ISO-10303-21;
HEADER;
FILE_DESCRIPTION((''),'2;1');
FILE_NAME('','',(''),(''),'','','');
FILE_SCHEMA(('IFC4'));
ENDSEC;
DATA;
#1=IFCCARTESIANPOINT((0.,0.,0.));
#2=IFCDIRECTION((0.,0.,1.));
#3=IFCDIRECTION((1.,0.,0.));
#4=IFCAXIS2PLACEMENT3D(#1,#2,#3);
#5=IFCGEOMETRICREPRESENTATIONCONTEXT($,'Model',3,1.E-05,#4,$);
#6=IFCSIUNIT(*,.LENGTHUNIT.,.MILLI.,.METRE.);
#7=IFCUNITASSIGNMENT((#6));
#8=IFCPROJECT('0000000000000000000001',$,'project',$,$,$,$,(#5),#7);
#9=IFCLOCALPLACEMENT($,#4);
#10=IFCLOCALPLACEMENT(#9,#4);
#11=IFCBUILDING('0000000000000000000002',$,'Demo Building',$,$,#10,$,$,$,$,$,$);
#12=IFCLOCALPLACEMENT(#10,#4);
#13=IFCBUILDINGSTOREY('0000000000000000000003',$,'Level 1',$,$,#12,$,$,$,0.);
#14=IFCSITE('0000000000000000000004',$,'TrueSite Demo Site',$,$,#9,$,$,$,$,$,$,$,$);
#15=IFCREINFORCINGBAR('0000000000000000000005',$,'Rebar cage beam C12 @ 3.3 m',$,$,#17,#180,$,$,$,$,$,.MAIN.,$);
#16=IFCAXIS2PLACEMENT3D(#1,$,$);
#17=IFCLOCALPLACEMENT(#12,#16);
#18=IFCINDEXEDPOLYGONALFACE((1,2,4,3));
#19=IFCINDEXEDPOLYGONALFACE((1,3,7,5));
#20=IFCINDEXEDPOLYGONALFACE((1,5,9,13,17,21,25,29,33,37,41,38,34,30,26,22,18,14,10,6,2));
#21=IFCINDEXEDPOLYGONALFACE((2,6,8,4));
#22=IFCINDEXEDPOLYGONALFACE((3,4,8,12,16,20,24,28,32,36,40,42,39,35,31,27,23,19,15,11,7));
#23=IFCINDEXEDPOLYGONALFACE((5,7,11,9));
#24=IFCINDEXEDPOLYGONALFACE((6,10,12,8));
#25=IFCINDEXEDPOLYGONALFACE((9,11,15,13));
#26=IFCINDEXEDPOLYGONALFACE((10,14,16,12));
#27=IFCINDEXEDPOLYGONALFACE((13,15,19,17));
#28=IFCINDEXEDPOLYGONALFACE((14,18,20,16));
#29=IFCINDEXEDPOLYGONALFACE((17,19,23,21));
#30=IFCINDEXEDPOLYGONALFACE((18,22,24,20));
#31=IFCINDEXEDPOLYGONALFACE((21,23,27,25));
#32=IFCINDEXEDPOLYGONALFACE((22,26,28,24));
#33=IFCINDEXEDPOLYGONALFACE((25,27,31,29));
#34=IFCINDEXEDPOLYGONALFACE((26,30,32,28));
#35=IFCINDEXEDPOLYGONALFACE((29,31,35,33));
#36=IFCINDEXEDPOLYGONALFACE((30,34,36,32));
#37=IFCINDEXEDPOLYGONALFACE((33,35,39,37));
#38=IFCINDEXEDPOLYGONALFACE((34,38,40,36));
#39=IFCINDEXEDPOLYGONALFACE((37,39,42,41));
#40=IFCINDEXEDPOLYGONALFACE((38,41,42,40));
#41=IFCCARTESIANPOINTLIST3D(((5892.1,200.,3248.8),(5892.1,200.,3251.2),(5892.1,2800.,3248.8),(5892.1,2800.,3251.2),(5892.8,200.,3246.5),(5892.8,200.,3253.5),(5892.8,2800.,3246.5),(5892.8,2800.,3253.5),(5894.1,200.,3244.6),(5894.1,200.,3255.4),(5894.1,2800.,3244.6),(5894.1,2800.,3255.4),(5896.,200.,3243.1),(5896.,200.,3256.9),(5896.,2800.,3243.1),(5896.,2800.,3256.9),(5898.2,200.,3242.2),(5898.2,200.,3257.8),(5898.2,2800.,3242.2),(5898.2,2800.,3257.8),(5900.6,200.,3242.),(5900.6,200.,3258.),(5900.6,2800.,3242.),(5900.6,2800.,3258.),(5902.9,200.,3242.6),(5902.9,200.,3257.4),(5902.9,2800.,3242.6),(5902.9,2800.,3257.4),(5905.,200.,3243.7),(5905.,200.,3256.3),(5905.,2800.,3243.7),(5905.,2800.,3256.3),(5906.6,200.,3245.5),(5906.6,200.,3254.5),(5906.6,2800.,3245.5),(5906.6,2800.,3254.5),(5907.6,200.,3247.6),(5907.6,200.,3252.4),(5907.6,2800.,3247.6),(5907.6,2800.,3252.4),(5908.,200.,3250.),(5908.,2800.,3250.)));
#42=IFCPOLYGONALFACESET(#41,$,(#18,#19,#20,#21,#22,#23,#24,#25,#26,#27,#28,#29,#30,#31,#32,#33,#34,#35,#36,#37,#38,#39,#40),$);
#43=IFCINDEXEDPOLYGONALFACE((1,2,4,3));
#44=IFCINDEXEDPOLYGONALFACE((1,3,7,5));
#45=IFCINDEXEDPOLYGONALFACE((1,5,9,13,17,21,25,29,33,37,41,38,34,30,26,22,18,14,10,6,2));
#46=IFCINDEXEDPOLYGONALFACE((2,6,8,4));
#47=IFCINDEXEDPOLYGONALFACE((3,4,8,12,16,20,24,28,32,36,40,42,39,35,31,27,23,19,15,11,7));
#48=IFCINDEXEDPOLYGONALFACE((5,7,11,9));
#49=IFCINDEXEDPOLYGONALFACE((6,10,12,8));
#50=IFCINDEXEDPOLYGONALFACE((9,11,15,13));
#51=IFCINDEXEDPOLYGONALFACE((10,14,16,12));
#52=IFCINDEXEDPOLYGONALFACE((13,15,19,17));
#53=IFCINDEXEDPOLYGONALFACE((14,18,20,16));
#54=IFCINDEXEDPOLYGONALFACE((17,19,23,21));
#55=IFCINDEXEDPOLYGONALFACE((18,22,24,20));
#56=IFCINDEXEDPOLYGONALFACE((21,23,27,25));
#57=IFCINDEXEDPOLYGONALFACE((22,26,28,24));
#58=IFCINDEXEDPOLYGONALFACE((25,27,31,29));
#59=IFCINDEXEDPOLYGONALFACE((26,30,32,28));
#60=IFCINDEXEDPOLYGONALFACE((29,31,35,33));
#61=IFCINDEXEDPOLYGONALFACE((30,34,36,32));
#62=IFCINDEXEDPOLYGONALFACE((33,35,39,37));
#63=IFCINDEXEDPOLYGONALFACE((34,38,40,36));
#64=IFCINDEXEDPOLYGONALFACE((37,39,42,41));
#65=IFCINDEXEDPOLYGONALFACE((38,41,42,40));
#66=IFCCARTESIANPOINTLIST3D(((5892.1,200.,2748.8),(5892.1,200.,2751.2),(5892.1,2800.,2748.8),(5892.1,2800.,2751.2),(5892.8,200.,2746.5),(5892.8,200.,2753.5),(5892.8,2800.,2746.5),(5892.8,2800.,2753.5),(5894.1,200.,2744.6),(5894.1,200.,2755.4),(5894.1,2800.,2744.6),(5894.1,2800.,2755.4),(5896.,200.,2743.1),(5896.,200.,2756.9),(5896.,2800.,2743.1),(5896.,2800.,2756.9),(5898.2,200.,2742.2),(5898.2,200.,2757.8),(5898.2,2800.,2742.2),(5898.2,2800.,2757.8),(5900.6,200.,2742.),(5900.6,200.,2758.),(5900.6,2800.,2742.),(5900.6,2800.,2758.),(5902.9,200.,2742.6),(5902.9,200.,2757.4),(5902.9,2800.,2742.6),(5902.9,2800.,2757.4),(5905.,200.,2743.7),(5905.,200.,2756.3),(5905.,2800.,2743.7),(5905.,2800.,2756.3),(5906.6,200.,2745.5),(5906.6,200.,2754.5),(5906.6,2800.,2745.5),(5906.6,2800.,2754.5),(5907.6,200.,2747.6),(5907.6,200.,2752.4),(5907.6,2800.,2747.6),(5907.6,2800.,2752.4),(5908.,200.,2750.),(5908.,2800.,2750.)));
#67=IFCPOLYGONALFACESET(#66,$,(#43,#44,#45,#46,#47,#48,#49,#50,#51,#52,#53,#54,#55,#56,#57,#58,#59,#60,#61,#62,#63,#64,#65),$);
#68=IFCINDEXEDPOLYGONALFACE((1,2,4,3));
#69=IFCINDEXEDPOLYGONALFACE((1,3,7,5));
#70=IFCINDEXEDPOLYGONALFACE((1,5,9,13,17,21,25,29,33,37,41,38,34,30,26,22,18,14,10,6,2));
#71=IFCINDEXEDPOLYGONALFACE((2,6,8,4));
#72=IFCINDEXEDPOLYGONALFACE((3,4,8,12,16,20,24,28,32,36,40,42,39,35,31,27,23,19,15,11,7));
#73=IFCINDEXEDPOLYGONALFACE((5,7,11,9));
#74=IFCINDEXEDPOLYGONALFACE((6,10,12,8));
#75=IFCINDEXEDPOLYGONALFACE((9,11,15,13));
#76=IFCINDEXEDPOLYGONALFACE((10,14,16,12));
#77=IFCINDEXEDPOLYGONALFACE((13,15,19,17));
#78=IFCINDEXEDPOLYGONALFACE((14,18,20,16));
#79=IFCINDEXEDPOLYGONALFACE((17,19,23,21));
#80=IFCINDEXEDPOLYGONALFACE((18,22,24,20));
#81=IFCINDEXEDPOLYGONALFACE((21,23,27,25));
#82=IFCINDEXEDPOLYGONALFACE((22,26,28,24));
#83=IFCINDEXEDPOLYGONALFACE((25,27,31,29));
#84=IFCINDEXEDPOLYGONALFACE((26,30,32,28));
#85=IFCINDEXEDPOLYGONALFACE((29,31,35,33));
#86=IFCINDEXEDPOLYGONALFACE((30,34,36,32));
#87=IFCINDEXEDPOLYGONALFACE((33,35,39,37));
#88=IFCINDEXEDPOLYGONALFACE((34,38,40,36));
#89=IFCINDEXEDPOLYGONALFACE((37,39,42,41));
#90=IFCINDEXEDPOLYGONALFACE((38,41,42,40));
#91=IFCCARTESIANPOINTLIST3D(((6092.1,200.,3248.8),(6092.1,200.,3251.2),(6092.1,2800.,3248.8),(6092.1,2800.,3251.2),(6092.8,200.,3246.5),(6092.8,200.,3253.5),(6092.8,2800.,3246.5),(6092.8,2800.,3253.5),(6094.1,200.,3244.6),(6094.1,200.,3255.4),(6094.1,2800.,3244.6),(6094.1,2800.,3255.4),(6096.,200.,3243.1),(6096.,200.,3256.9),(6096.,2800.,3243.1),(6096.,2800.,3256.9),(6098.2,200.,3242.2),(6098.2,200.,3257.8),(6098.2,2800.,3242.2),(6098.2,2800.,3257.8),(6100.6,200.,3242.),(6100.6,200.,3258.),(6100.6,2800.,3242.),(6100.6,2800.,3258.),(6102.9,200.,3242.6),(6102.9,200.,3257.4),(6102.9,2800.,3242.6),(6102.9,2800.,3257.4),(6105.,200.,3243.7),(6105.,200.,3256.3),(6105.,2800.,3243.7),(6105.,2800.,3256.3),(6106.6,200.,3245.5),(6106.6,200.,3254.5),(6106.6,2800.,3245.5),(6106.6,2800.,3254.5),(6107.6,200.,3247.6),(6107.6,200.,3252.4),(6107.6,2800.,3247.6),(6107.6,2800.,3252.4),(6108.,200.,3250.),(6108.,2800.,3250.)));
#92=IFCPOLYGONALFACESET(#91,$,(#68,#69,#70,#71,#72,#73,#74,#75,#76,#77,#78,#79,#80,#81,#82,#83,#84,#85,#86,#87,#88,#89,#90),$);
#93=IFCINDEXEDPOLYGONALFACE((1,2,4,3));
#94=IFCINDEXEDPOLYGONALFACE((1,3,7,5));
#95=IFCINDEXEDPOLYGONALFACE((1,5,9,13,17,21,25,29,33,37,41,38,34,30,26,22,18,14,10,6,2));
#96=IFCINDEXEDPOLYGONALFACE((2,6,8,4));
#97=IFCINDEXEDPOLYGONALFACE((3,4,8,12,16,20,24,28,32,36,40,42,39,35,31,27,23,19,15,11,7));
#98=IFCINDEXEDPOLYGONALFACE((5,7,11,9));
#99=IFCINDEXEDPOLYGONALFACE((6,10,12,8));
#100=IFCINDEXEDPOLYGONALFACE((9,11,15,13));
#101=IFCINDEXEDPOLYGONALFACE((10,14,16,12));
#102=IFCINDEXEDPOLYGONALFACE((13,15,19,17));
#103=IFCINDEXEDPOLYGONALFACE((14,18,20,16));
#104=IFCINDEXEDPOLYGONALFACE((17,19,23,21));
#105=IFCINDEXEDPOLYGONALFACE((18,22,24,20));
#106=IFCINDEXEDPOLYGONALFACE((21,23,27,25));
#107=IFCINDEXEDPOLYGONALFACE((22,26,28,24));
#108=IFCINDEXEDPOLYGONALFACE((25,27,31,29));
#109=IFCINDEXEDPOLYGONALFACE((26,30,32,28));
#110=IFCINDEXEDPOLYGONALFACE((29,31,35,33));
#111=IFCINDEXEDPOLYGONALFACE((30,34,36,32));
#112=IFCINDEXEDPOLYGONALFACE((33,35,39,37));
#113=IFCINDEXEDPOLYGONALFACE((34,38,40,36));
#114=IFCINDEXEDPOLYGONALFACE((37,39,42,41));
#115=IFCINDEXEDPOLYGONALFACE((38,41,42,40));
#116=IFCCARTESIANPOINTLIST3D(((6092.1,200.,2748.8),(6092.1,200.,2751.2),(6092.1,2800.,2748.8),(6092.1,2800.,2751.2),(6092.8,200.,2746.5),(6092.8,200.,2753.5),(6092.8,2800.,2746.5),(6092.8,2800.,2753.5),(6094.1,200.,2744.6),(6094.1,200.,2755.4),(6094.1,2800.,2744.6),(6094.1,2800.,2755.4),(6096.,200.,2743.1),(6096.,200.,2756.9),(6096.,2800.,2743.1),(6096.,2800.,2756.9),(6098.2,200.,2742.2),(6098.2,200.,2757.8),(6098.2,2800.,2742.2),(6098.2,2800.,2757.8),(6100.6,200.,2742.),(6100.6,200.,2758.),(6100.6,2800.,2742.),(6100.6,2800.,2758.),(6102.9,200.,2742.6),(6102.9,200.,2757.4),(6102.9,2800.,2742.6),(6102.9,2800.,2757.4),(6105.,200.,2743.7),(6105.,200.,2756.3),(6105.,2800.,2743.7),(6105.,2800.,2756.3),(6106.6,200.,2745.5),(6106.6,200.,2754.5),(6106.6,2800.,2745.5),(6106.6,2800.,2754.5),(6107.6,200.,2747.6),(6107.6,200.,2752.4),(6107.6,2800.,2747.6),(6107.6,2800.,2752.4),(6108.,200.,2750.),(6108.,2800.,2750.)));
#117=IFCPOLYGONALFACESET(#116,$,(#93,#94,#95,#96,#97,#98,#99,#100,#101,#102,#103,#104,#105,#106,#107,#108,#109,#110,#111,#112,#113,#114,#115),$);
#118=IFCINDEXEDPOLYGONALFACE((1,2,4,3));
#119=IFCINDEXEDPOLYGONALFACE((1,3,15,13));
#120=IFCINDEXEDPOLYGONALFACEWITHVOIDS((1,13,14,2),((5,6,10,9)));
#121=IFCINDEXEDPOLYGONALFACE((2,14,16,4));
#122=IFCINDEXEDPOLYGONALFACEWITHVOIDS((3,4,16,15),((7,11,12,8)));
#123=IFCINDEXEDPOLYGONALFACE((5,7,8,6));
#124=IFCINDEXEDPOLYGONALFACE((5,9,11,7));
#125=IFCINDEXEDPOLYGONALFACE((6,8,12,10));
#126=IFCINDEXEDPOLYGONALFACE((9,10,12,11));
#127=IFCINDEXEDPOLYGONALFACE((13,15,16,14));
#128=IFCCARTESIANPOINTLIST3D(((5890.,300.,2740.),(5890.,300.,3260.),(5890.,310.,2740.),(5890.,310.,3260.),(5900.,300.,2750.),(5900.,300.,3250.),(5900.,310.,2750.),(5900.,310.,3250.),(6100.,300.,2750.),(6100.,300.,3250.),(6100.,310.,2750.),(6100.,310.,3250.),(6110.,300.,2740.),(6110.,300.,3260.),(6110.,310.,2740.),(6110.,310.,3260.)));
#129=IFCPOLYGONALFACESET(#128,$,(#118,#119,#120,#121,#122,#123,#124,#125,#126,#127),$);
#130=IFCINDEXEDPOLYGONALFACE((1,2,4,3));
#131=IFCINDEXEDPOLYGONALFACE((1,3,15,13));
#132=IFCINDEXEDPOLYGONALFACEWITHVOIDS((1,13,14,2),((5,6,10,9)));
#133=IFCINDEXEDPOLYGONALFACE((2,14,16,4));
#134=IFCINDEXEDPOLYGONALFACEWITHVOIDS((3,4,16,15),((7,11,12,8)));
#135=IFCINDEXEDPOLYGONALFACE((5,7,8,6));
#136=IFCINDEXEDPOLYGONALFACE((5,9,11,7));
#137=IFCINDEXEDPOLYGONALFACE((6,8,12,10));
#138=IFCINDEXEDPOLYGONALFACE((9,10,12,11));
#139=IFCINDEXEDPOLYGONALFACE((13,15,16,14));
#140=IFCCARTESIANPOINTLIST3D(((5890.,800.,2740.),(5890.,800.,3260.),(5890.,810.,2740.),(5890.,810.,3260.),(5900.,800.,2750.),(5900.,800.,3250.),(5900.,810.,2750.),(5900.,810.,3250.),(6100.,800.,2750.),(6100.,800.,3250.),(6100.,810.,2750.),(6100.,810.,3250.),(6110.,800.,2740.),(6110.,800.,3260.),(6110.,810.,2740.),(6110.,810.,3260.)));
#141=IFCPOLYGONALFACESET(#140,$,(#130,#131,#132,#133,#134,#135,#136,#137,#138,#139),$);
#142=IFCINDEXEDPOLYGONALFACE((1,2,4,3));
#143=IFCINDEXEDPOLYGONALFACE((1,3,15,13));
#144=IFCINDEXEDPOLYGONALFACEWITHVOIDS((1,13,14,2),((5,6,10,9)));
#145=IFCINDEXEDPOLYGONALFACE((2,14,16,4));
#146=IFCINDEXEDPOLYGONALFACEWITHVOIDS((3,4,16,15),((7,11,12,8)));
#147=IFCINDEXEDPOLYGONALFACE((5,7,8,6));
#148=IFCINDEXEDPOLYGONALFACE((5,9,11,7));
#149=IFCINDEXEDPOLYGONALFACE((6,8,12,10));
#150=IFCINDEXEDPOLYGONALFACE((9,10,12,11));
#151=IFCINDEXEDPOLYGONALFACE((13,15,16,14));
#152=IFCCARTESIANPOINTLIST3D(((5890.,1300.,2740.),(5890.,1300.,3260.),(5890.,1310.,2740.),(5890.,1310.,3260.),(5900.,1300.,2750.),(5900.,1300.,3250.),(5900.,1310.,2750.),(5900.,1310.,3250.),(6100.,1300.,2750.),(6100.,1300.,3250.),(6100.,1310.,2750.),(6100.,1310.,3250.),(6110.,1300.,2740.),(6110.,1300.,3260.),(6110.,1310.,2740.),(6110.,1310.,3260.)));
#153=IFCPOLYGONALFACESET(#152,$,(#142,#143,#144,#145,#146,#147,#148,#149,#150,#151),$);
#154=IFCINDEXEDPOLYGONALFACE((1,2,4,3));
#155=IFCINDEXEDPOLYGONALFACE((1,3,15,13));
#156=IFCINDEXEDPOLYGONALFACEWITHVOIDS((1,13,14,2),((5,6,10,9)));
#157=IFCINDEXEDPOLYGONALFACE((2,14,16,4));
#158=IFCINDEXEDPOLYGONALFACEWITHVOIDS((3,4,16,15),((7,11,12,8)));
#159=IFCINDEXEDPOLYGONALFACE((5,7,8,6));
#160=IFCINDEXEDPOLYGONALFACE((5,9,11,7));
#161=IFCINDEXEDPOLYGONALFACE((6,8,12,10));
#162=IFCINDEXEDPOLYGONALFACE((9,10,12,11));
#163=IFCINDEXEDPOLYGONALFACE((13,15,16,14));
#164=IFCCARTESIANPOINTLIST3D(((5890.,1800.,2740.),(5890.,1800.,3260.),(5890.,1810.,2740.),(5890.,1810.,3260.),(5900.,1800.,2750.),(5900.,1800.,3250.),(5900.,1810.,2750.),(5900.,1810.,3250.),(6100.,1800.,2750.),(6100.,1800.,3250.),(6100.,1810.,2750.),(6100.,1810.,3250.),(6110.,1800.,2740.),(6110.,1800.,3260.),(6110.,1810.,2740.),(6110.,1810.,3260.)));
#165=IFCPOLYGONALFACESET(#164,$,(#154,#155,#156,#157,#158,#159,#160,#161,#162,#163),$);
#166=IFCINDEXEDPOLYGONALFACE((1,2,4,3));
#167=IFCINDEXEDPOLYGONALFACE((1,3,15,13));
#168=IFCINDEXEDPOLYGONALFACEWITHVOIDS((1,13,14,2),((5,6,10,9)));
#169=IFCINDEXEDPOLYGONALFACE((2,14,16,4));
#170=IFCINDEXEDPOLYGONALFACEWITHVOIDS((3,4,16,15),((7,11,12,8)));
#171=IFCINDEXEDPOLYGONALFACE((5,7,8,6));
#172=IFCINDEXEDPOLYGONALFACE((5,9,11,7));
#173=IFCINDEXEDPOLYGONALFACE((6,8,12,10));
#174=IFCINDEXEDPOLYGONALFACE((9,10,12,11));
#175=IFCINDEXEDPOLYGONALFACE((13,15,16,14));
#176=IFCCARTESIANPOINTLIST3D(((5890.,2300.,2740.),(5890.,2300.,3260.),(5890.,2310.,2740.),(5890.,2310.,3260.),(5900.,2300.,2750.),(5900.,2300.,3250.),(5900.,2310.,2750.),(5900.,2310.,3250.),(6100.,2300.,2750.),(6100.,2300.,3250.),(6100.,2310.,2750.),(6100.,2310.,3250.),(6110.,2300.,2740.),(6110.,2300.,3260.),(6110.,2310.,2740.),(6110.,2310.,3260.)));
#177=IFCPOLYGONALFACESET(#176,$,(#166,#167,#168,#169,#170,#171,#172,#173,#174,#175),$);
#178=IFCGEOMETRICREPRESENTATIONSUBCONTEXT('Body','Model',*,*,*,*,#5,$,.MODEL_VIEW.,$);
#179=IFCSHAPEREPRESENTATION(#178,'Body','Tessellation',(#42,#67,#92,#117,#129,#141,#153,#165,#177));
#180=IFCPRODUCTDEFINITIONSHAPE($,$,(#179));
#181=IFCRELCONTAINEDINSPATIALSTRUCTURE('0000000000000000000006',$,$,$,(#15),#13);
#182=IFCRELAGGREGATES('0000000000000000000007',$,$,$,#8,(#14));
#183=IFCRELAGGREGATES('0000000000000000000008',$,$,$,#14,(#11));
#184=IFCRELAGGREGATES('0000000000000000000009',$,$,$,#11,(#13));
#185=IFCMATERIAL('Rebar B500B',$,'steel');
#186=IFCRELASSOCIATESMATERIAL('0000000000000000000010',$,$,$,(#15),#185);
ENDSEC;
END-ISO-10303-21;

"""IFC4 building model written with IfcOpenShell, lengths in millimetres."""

from ifc_helpers import new_model, si_unit, frame, origin_with_axes, place, context, subcontext, project, spatial, hollow_rectangle, circle, extrude, material, element, save


model = new_model("IFC4")

# Units and contexts
model_context = context("Model", 3, precision=1e-05, world=origin_with_axes())
body_context = subcontext(model_context, "Body", "Model", "MODEL_VIEW")
ifc_project = project(units=[si_unit("LENGTHUNIT", "METRE", prefix="MILLI")], contexts=[model_context])

# Site, building, storey
site_placement = place(None, origin_with_axes())
site = spatial("IfcSite", under=ifc_project, at=site_placement, Name="TrueSite Demo Site")
building_placement = place(site_placement, origin_with_axes())
building = spatial("IfcBuilding", under=site, at=building_placement, Name="Demo Building")
storey_placement = place(building_placement, origin_with_axes())
storey = spatial("IfcBuildingStorey", under=building, at=storey_placement, Name="Level 1", Elevation=0.0)

# Reinforcing bar
ifc_material_1 = material(Name="Rebar B500B", Category="steel")
for number, where, z_axis, x_axis, name in (
    (1, (6000.0, 200.0, 3000.0), (0.0, 1.0, 0.0), (1.0, 0.0, 0.0), "Rebar cage beam C12 @ 3.3 m"),
):
    element("IfcReinforcingBar", number, at=place(storey_placement, frame(where, z_axis=z_axis, x_axis=x_axis)), inside=storey, material=ifc_material_1, Name=name, PredefinedType="MAIN", context=body_context, shape_type="SweptSolid", body=[
        extrude(circle(Radius=8.0), frame((-100.0, -250.0, 0.0)), (0.0, 0.0, 1.0), 2600.0),
        extrude(circle(Radius=8.0), frame((-100.0, 250.0, 0.0)), (0.0, 0.0, 1.0), 2600.0),
        extrude(circle(Radius=8.0), frame((100.0, -250.0, 0.0)), (0.0, 0.0, 1.0), 2600.0),
        extrude(circle(Radius=8.0), frame((100.0, 250.0, 0.0)), (0.0, 0.0, 1.0), 2600.0),
        extrude(hollow_rectangle(XDim=220.0, YDim=520.0, WallThickness=10.0), frame((0.0, 0.0, 100.0)), (0.0, 0.0, 1.0), 10.0),
        extrude(hollow_rectangle(XDim=220.0, YDim=520.0, WallThickness=10.0), frame((0.0, 0.0, 600.0)), (0.0, 0.0, 1.0), 10.0),
        extrude(hollow_rectangle(XDim=220.0, YDim=520.0, WallThickness=10.0), frame((0.0, 0.0, 1100.0)), (0.0, 0.0, 1.0), 10.0),
        extrude(hollow_rectangle(XDim=220.0, YDim=520.0, WallThickness=10.0), frame((0.0, 0.0, 1600.0)), (0.0, 0.0, 1.0), 10.0),
        extrude(hollow_rectangle(XDim=220.0, YDim=520.0, WallThickness=10.0), frame((0.0, 0.0, 2100.0)), (0.0, 0.0, 1.0), 10.0),
    ])

save(model, "model.ifc")
